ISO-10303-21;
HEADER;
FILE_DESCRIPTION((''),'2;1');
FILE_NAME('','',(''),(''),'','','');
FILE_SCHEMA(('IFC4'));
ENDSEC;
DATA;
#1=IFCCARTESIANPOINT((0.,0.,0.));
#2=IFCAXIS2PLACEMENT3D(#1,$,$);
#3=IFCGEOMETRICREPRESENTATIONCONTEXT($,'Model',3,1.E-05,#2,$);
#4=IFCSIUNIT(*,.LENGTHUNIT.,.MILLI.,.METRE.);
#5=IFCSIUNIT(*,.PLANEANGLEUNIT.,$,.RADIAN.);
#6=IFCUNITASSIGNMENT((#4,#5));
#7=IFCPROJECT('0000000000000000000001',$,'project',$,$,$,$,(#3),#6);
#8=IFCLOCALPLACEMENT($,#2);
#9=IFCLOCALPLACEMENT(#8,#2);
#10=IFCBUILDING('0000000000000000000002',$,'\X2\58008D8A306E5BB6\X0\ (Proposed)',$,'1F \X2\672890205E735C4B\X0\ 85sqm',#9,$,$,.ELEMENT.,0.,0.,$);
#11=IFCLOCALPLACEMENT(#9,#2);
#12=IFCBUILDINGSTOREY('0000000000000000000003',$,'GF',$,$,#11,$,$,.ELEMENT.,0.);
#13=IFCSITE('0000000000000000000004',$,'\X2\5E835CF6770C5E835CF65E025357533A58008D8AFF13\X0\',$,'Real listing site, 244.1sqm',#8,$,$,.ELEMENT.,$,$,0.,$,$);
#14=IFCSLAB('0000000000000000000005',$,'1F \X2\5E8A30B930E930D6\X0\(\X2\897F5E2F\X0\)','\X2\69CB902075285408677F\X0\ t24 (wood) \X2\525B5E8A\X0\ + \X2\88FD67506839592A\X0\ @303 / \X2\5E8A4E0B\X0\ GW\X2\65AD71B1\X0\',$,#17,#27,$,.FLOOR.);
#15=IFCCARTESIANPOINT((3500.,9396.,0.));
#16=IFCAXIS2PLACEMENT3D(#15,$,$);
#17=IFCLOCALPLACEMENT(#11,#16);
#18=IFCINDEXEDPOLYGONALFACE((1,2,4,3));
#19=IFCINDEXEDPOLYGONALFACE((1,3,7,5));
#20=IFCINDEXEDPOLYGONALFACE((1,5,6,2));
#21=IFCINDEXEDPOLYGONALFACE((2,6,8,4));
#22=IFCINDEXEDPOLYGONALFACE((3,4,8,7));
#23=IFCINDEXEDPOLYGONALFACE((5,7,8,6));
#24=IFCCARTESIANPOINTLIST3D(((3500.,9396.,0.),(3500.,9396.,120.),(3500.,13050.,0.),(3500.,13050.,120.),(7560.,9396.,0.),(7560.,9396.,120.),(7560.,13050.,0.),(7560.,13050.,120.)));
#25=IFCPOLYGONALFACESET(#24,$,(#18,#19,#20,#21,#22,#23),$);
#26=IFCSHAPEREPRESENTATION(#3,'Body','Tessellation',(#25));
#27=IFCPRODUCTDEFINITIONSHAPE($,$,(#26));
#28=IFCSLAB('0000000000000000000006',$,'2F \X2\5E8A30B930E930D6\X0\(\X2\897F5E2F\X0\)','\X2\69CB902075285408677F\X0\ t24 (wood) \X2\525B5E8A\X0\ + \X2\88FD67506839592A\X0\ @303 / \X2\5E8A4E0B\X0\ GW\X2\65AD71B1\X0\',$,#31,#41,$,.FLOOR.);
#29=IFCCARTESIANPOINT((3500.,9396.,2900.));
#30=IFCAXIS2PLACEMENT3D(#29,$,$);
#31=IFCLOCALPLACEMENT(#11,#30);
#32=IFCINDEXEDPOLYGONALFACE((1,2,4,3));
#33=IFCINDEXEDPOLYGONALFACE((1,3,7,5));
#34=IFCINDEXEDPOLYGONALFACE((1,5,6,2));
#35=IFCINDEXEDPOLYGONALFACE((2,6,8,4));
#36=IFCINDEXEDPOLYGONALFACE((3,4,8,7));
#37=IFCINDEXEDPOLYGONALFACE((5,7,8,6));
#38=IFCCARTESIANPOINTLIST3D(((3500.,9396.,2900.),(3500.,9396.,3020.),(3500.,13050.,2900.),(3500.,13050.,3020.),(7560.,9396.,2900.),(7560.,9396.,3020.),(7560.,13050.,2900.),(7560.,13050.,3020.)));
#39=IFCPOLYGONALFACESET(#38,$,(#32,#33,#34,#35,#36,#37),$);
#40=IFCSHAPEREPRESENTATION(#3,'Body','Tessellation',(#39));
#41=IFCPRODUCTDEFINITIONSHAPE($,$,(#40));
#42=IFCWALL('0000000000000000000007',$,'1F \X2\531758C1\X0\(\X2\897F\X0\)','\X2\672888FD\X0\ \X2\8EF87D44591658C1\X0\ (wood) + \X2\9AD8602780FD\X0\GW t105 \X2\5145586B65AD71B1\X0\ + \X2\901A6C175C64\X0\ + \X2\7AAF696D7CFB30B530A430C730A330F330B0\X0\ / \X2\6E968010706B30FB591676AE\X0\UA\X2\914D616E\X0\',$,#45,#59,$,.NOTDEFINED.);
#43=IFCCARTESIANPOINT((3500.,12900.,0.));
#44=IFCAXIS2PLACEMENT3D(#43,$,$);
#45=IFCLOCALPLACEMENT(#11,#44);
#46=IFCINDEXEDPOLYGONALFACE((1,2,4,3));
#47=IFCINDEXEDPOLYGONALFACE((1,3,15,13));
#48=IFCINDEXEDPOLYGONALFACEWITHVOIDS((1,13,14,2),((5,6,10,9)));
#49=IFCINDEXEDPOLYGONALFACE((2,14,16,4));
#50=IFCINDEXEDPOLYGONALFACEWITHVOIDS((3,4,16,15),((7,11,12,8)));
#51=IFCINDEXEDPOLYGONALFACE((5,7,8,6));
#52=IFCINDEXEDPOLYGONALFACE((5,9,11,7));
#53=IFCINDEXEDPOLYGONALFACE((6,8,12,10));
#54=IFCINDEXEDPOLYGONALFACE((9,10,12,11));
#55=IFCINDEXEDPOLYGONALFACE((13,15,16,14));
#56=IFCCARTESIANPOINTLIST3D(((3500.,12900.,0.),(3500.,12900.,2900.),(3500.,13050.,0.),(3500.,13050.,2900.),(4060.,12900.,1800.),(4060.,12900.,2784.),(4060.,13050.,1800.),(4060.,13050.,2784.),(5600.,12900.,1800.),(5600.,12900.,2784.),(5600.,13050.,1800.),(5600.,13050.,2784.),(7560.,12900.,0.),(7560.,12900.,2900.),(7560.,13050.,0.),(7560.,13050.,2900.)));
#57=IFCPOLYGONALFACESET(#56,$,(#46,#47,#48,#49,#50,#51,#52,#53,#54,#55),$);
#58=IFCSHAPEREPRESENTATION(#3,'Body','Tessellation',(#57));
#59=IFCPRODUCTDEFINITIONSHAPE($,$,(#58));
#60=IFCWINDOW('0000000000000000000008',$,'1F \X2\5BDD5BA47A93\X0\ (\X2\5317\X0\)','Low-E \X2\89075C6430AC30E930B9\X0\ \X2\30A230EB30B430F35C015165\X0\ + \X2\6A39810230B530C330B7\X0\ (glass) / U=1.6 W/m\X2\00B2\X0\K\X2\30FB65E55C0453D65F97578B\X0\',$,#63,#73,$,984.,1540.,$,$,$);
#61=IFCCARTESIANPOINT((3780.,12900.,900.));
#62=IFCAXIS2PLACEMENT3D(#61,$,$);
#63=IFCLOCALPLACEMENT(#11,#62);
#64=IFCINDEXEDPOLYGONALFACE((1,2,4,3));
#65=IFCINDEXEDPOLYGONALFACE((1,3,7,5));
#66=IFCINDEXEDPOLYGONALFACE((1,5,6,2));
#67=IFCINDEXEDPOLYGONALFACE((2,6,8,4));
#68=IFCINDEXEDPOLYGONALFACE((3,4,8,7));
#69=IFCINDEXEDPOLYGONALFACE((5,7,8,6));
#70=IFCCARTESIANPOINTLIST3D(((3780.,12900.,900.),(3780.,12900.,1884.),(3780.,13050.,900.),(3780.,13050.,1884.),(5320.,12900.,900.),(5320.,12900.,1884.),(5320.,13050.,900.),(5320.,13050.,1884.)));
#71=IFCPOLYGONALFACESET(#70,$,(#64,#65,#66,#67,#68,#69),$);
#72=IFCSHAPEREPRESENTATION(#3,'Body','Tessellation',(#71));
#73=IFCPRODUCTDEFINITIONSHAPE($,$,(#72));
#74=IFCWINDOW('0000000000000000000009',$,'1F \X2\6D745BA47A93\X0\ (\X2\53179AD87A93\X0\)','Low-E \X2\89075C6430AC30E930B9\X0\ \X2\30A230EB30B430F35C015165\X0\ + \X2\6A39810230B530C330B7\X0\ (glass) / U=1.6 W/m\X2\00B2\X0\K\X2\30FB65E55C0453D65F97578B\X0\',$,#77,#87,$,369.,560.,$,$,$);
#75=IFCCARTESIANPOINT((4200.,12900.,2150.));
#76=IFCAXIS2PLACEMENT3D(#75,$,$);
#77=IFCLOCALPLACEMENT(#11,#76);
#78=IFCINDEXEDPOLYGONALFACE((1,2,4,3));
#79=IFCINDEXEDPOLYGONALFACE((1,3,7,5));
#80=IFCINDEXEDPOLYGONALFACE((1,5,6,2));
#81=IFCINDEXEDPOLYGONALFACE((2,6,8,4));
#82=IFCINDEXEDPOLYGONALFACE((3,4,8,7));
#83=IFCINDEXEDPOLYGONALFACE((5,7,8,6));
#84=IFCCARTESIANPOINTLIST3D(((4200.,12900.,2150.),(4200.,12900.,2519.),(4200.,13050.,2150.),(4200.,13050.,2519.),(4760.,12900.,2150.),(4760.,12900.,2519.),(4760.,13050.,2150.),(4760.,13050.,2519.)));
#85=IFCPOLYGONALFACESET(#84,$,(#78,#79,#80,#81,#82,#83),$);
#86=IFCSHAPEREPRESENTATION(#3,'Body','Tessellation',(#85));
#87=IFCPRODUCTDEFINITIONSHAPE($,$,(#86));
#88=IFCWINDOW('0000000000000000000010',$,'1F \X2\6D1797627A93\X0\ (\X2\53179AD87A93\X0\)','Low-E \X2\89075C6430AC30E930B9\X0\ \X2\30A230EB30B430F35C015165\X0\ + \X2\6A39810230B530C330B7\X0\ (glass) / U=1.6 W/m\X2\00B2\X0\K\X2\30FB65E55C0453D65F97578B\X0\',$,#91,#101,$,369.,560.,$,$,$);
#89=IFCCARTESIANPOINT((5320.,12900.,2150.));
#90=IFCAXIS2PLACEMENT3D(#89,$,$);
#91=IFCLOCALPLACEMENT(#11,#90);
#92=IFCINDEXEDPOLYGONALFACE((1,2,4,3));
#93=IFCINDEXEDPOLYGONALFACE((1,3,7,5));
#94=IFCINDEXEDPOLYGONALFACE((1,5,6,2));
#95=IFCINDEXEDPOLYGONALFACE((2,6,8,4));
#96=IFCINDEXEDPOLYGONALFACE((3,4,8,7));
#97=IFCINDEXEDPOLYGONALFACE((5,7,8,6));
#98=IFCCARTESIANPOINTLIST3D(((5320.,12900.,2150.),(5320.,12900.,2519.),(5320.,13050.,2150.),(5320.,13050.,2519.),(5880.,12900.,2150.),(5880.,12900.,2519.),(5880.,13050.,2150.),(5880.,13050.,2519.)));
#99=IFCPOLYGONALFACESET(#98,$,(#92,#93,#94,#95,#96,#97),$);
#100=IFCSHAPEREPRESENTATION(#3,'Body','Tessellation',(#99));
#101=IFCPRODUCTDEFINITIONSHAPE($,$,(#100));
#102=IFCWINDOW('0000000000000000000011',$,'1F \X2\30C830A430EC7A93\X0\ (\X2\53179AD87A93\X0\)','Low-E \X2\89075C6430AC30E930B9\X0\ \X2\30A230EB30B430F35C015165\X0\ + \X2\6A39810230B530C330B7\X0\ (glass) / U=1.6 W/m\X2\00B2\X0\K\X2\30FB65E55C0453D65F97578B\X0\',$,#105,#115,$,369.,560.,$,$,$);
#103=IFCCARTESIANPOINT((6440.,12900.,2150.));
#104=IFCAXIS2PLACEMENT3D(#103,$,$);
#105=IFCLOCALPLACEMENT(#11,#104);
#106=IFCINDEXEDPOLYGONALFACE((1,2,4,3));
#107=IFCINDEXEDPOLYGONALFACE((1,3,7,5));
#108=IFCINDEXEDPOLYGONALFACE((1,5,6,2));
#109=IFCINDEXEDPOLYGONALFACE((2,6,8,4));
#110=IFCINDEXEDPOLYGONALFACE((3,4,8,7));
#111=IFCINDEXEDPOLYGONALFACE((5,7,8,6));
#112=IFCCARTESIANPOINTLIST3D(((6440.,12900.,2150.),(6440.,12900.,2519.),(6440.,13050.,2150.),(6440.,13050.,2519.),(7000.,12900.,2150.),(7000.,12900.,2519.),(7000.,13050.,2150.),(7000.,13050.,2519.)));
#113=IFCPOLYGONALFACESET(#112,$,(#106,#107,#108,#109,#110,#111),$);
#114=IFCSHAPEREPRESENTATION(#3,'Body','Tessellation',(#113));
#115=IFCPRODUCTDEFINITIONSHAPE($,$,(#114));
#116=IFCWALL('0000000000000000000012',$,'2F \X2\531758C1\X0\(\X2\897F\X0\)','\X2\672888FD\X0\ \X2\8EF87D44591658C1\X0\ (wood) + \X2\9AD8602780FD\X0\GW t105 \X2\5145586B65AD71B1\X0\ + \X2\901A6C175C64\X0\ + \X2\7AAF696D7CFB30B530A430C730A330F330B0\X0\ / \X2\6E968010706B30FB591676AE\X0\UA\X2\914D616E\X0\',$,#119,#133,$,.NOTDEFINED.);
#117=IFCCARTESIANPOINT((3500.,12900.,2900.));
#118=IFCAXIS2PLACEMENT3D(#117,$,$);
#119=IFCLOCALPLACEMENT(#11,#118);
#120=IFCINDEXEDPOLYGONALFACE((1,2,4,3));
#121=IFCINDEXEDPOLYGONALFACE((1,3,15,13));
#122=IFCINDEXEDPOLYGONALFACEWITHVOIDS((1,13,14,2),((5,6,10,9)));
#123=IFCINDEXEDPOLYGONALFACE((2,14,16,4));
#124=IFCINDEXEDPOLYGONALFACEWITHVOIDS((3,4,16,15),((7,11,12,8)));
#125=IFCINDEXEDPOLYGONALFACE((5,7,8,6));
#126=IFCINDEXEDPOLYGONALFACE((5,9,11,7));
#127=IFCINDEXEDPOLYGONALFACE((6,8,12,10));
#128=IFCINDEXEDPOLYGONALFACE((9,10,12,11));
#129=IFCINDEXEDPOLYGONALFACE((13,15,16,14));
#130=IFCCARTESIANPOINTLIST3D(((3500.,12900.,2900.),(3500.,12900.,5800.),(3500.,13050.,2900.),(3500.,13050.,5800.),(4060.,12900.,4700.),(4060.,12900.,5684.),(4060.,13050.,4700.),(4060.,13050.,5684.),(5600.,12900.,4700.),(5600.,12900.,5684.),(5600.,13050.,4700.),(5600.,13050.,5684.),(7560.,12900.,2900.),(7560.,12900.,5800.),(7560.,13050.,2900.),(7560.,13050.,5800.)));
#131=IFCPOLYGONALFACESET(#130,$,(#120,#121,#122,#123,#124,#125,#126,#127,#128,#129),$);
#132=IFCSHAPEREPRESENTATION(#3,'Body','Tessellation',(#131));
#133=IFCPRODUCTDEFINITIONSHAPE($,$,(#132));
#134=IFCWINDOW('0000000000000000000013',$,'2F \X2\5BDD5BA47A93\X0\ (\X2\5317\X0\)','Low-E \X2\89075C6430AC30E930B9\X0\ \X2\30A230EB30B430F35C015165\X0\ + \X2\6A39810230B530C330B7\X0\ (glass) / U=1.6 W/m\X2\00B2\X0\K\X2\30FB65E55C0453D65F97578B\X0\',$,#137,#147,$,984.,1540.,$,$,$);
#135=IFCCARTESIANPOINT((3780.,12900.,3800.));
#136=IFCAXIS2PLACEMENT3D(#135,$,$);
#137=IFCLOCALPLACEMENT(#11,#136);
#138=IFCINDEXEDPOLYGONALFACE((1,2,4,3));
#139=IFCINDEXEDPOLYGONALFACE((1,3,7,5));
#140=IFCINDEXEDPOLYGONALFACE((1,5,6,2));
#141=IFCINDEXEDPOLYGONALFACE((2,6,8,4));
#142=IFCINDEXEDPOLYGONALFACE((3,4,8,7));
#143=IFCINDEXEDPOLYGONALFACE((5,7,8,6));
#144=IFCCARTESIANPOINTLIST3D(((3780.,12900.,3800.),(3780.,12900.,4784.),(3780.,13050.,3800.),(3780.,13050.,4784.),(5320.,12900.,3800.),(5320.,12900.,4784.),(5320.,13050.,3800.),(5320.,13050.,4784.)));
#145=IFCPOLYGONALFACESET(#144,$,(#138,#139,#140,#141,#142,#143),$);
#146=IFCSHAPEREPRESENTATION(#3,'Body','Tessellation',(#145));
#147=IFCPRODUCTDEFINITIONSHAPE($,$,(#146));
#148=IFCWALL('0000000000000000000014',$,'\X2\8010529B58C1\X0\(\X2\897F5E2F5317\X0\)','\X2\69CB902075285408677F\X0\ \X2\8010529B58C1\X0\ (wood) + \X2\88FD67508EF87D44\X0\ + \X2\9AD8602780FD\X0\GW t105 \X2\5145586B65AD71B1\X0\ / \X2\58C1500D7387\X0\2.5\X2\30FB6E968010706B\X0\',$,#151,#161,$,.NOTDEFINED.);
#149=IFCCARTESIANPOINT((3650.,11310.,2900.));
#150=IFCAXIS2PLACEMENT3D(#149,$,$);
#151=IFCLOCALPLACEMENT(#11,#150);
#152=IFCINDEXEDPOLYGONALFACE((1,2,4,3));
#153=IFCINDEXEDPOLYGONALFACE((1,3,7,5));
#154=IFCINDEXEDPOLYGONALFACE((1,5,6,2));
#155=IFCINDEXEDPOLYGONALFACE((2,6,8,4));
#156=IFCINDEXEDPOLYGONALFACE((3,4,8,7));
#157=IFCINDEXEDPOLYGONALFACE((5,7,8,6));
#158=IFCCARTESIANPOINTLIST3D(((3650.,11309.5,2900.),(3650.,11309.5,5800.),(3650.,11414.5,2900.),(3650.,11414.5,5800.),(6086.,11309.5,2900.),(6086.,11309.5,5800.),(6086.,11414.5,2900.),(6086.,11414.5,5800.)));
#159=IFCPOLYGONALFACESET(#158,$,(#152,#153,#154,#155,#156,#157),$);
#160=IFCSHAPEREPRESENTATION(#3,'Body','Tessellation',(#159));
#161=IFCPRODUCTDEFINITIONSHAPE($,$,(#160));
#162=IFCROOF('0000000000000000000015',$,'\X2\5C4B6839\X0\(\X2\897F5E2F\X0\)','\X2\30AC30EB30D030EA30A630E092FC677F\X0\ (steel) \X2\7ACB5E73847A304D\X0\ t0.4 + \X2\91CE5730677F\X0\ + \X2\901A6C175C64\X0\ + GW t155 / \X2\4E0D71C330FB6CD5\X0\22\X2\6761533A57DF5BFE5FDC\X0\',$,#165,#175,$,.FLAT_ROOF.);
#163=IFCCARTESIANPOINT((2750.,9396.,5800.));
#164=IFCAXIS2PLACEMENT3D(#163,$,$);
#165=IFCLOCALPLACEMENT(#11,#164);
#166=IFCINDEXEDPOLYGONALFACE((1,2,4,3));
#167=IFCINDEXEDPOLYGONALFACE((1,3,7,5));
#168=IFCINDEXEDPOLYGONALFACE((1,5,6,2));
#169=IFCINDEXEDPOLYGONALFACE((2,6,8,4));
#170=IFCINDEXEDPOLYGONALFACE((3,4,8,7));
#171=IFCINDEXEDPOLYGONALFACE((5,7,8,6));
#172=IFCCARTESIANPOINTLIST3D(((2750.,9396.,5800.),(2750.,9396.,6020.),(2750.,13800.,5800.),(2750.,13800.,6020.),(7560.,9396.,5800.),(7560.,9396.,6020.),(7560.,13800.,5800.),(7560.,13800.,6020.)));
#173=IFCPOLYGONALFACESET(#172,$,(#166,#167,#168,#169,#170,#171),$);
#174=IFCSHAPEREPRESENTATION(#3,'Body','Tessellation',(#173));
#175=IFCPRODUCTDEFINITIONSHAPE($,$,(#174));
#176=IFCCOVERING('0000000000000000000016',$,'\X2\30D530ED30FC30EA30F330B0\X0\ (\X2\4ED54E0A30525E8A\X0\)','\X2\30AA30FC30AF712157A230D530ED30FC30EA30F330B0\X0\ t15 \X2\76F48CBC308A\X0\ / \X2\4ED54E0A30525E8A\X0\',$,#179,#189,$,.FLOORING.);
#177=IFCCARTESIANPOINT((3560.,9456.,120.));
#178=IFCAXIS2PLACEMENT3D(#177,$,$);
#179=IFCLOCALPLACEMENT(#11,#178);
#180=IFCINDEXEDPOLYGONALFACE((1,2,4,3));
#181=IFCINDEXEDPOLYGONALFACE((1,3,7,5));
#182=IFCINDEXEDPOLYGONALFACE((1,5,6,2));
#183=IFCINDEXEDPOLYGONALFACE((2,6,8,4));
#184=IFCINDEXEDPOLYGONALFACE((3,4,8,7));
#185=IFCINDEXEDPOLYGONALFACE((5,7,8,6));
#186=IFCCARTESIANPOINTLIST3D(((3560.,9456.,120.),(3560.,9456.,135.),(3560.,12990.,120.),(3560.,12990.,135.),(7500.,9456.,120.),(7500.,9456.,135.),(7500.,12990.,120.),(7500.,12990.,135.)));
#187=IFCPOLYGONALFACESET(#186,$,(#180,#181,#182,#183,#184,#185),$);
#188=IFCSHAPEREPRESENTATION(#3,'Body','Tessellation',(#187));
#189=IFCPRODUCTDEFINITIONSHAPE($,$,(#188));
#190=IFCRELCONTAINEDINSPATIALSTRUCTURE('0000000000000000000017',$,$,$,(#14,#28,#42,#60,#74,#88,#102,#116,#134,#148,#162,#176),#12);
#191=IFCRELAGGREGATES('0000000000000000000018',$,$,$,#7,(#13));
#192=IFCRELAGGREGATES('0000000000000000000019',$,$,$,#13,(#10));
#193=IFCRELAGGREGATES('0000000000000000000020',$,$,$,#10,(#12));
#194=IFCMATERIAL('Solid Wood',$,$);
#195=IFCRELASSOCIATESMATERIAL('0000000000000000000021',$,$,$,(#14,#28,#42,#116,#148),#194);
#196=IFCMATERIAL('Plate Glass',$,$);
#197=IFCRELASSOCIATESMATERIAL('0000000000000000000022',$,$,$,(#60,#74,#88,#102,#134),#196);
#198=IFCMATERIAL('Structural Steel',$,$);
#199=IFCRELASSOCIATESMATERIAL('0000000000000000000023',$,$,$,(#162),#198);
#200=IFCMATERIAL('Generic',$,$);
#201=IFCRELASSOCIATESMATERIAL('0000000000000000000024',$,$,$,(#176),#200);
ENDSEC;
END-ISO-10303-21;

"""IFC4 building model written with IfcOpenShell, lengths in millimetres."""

from ifc_helpers import new_model, si_unit, frame, frame_2d, origin, place, context, project, spatial, rectangle, extrude, material, element, fill, save


model = new_model("IFC4")

# Units and contexts
model_context = context("Model", 3, precision=1e-05, world=origin())
ifc_project = project(units=[si_unit("LENGTHUNIT", "METRE", prefix="MILLI"), si_unit("PLANEANGLEUNIT", "RADIAN")], contexts=[model_context])

# Site, building, storey
site_placement = place(None, origin())
site = spatial("IfcSite", under=ifc_project, at=site_placement, Name="広島県広島市南区堀越３", ObjectType="Real listing site, 244.1sqm", CompositionType="ELEMENT", RefElevation=0.0)
building_placement = place(site_placement, origin())
building = spatial("IfcBuilding", under=site, at=building_placement, Name="堀越の家 (Proposed)", ObjectType="1F 木造平屋 85sqm", CompositionType="ELEMENT", ElevationOfRefHeight=0.0, ElevationOfTerrain=0.0)
storey_placement = place(building_placement, origin())
storey = spatial("IfcBuildingStorey", under=building, at=storey_placement, Name="GF", CompositionType="ELEMENT", Elevation=0.0)

# Slabs
ifc_material_1 = material(Name="Solid Wood")
slab_1_placement = place(storey_placement, frame((3500.0, 9396.0, 0.0)))
element("IfcSlab", 1, at=slab_1_placement, inside=storey, material=ifc_material_1, Name="1F 床スラブ(西帯)", Description="構造用合板 t24 (wood) 剛床 + 製材根太 @303 / 床下 GW断熱", PredefinedType="FLOOR", context=model_context, shape_type="SweptSolid", body=[
    extrude(rectangle(XDim=4060.0, YDim=3654.0, at=frame_2d((2030.0, 1827.0))), frame((3500.0, 9396.0, 0.0)), (0.0, 0.0, 1.0), 120.0),
])
slab_2_placement = place(storey_placement, frame((3500.0, 9396.0, 2900.0)))
element("IfcSlab", 2, at=slab_2_placement, inside=storey, material=ifc_material_1, Name="2F 床スラブ(西帯)", Description="構造用合板 t24 (wood) 剛床 + 製材根太 @303 / 床下 GW断熱", PredefinedType="FLOOR", context=model_context, shape_type="SweptSolid", body=[
    extrude(rectangle(XDim=4060.0, YDim=3654.0, at=frame_2d((2030.0, 1827.0))), frame((3500.0, 9396.0, 2900.0)), (0.0, 0.0, 1.0), 120.0),
])

# Wall, openings, windows
wall_1_placement = place(storey_placement, frame((3500.0, 12900.0, 0.0)))
wall_1 = element("IfcWall", 3, at=wall_1_placement, inside=storey, material=ifc_material_1, Name="1F 北壁(西)", Description="木製 軸組外壁 (wood) + 高性能GW t105 充填断熱 + 通気層 + 窯業系サイディング / 準耐火・外皮UA配慮", PredefinedType="NOTDEFINED", context=model_context, shape_type="SweptSolid", body=[
    extrude(rectangle(XDim=4060.0, YDim=150.0, at=frame_2d((2030.0, 75.0))), frame((3500.0, 12900.0, 0.0)), (0.0, 0.0, 1.0), 2900.0),
])
opening_1_placement = place(storey_placement, frame((3780.0, 12900.0, 900.0)))
opening_1 = element("IfcOpeningElement", 4, at=opening_1_placement, cuts=wall_1, PredefinedType="NOTDEFINED", context=model_context, shape_type="SweptSolid", body=[
    extrude(rectangle(XDim=1540.0, YDim=150.0, at=frame_2d((770.0, 75.0))), frame((3780.0, 12900.0, 900.0)), (0.0, 0.0, 1.0), 984.0),
])
opening_2_placement = place(storey_placement, frame((4200.0, 12900.0, 2150.0)))
opening_2 = element("IfcOpeningElement", 5, at=opening_2_placement, cuts=wall_1, PredefinedType="NOTDEFINED", context=model_context, shape_type="SweptSolid", body=[
    extrude(rectangle(XDim=560.0, YDim=150.0, at=frame_2d((280.0, 75.0))), frame((4200.0, 12900.0, 2150.0)), (0.0, 0.0, 1.0), 369.0),
])
opening_3_placement = place(storey_placement, frame((5320.0, 12900.0, 2150.0)))
opening_3 = element("IfcOpeningElement", 6, at=opening_3_placement, cuts=wall_1, PredefinedType="NOTDEFINED", context=model_context, shape_type="SweptSolid", body=[
    extrude(rectangle(XDim=560.0, YDim=150.0, at=frame_2d((280.0, 75.0))), frame((5320.0, 12900.0, 2150.0)), (0.0, 0.0, 1.0), 369.0),
])
opening_4_placement = place(storey_placement, frame((6440.0, 12900.0, 2150.0)))
opening_4 = element("IfcOpeningElement", 7, at=opening_4_placement, cuts=wall_1, PredefinedType="NOTDEFINED", context=model_context, shape_type="SweptSolid", body=[
    extrude(rectangle(XDim=560.0, YDim=150.0, at=frame_2d((280.0, 75.0))), frame((6440.0, 12900.0, 2150.0)), (0.0, 0.0, 1.0), 369.0),
])
ifc_material_2 = material(Name="Plate Glass")
window_1_placement = place(storey_placement, frame((3780.0, 12900.0, 900.0)))
window_1 = element("IfcWindow", 8, at=window_1_placement, inside=storey, material=ifc_material_2, Name="1F 寝室窓 (北)", Description="Low-E 複層ガラス アルゴン封入 + 樹脂サッシ (glass) / U=1.6 W/m²K・日射取得型", OverallHeight=984.0, OverallWidth=1540.0, context=model_context, shape_type="SweptSolid", body=[
    extrude(rectangle(XDim=1540.0, YDim=150.0, at=frame_2d((770.0, 75.0))), frame((3780.0, 12900.0, 900.0)), (0.0, 0.0, 1.0), 984.0),
])
fill(opening_1, window_1)
window_2_placement = place(storey_placement, frame((4200.0, 12900.0, 2150.0)))
window_2 = element("IfcWindow", 9, at=window_2_placement, inside=storey, material=ifc_material_2, Name="1F 浴室窓 (北高窓)", Description="Low-E 複層ガラス アルゴン封入 + 樹脂サッシ (glass) / U=1.6 W/m²K・日射取得型", OverallHeight=369.0, OverallWidth=560.0, context=model_context, shape_type="SweptSolid", body=[
    extrude(rectangle(XDim=560.0, YDim=150.0, at=frame_2d((280.0, 75.0))), frame((4200.0, 12900.0, 2150.0)), (0.0, 0.0, 1.0), 369.0),
])
fill(opening_2, window_2)
window_3_placement = place(storey_placement, frame((5320.0, 12900.0, 2150.0)))
window_3 = element("IfcWindow", 10, at=window_3_placement, inside=storey, material=ifc_material_2, Name="1F 洗面窓 (北高窓)", Description="Low-E 複層ガラス アルゴン封入 + 樹脂サッシ (glass) / U=1.6 W/m²K・日射取得型", OverallHeight=369.0, OverallWidth=560.0, context=model_context, shape_type="SweptSolid", body=[
    extrude(rectangle(XDim=560.0, YDim=150.0, at=frame_2d((280.0, 75.0))), frame((5320.0, 12900.0, 2150.0)), (0.0, 0.0, 1.0), 369.0),
])
fill(opening_3, window_3)
window_4_placement = place(storey_placement, frame((6440.0, 12900.0, 2150.0)))
window_4 = element("IfcWindow", 11, at=window_4_placement, inside=storey, material=ifc_material_2, Name="1F トイレ窓 (北高窓)", Description="Low-E 複層ガラス アルゴン封入 + 樹脂サッシ (glass) / U=1.6 W/m²K・日射取得型", OverallHeight=369.0, OverallWidth=560.0, context=model_context, shape_type="SweptSolid", body=[
    extrude(rectangle(XDim=560.0, YDim=150.0, at=frame_2d((280.0, 75.0))), frame((6440.0, 12900.0, 2150.0)), (0.0, 0.0, 1.0), 369.0),
])
fill(opening_4, window_4)

# Wall, opening, window
wall_2_placement = place(storey_placement, frame((3500.0, 12900.0, 2900.0)))
wall_2 = element("IfcWall", 12, at=wall_2_placement, inside=storey, material=ifc_material_1, Name="2F 北壁(西)", Description="木製 軸組外壁 (wood) + 高性能GW t105 充填断熱 + 通気層 + 窯業系サイディング / 準耐火・外皮UA配慮", PredefinedType="NOTDEFINED", context=model_context, shape_type="SweptSolid", body=[
    extrude(rectangle(XDim=4060.0, YDim=150.0, at=frame_2d((2030.0, 75.0))), frame((3500.0, 12900.0, 2900.0)), (0.0, 0.0, 1.0), 2900.0),
])
opening_5_placement = place(storey_placement, frame((3780.0, 12900.0, 3800.0)))
opening_5 = element("IfcOpeningElement", 13, at=opening_5_placement, cuts=wall_2, PredefinedType="NOTDEFINED", context=model_context, shape_type="SweptSolid", body=[
    extrude(rectangle(XDim=1540.0, YDim=150.0, at=frame_2d((770.0, 75.0))), frame((3780.0, 12900.0, 3800.0)), (0.0, 0.0, 1.0), 984.0),
])
window_5_placement = place(storey_placement, frame((3780.0, 12900.0, 3800.0)))
window_5 = element("IfcWindow", 14, at=window_5_placement, inside=storey, material=ifc_material_2, Name="2F 寝室窓 (北)", Description="Low-E 複層ガラス アルゴン封入 + 樹脂サッシ (glass) / U=1.6 W/m²K・日射取得型", OverallHeight=984.0, OverallWidth=1540.0, context=model_context, shape_type="SweptSolid", body=[
    extrude(rectangle(XDim=1540.0, YDim=150.0, at=frame_2d((770.0, 75.0))), frame((3780.0, 12900.0, 3800.0)), (0.0, 0.0, 1.0), 984.0),
])
fill(opening_5, window_5)

# Wall
wall_3_placement = place(storey_placement, frame((3650.0, 11310.0, 2900.0)))
element("IfcWall", 15, at=wall_3_placement, inside=storey, material=ifc_material_1, Name="耐力壁(西帯北)", Description="構造用合板 耐力壁 (wood) + 製材軸組 + 高性能GW t105 充填断熱 / 壁倍率2.5・準耐火", PredefinedType="NOTDEFINED", context=model_context, shape_type="SweptSolid", body=[
    extrude(rectangle(XDim=2436.0, YDim=105.0, at=frame_2d((1218.0, 52.0))), frame((3650.0, 11310.0, 2900.0)), (0.0, 0.0, 1.0), 2900.0),
])

# Roof
ifc_material_3 = material(Name="Structural Steel")
for number, where, name in (
    (16, (2750.0, 9396.0, 5800.0), "屋根(西帯)"),
):
    element("IfcRoof", number, at=place(storey_placement, frame(where)), inside=storey, material=ifc_material_3, Name=name, Description="ガルバリウム鋼板 (steel) 立平葺き t0.4 + 野地板 + 通気層 + GW t155 / 不燃・法22条区域対応", PredefinedType="FLAT_ROOF", context=model_context, shape_type="SweptSolid", body=[
        extrude(rectangle(XDim=4810.0, YDim=4404.0, at=frame_2d((2405.0, 2202.0))), frame((2750.0, 9396.0, 5800.0)), (0.0, 0.0, 1.0), 220.0),
    ])

# Covering
ifc_material_4 = material(Name="Generic")
covering_1_placement = place(storey_placement, frame((3560.0, 9456.0, 120.0)))
element("IfcCovering", 17, at=covering_1_placement, inside=storey, material=ifc_material_4, Name="フローリング (仕上げ床)", Description="オーク無垢フローリング t15 直貼り / 仕上げ床", PredefinedType="FLOORING", context=model_context, shape_type="SweptSolid", body=[
    extrude(rectangle(XDim=3940.0, YDim=3534.0, at=frame_2d((1970.0, 1767.0))), frame((3560.0, 9456.0, 120.0)), (0.0, 0.0, 1.0), 15.0),
])

save(model, "model.ifc")
